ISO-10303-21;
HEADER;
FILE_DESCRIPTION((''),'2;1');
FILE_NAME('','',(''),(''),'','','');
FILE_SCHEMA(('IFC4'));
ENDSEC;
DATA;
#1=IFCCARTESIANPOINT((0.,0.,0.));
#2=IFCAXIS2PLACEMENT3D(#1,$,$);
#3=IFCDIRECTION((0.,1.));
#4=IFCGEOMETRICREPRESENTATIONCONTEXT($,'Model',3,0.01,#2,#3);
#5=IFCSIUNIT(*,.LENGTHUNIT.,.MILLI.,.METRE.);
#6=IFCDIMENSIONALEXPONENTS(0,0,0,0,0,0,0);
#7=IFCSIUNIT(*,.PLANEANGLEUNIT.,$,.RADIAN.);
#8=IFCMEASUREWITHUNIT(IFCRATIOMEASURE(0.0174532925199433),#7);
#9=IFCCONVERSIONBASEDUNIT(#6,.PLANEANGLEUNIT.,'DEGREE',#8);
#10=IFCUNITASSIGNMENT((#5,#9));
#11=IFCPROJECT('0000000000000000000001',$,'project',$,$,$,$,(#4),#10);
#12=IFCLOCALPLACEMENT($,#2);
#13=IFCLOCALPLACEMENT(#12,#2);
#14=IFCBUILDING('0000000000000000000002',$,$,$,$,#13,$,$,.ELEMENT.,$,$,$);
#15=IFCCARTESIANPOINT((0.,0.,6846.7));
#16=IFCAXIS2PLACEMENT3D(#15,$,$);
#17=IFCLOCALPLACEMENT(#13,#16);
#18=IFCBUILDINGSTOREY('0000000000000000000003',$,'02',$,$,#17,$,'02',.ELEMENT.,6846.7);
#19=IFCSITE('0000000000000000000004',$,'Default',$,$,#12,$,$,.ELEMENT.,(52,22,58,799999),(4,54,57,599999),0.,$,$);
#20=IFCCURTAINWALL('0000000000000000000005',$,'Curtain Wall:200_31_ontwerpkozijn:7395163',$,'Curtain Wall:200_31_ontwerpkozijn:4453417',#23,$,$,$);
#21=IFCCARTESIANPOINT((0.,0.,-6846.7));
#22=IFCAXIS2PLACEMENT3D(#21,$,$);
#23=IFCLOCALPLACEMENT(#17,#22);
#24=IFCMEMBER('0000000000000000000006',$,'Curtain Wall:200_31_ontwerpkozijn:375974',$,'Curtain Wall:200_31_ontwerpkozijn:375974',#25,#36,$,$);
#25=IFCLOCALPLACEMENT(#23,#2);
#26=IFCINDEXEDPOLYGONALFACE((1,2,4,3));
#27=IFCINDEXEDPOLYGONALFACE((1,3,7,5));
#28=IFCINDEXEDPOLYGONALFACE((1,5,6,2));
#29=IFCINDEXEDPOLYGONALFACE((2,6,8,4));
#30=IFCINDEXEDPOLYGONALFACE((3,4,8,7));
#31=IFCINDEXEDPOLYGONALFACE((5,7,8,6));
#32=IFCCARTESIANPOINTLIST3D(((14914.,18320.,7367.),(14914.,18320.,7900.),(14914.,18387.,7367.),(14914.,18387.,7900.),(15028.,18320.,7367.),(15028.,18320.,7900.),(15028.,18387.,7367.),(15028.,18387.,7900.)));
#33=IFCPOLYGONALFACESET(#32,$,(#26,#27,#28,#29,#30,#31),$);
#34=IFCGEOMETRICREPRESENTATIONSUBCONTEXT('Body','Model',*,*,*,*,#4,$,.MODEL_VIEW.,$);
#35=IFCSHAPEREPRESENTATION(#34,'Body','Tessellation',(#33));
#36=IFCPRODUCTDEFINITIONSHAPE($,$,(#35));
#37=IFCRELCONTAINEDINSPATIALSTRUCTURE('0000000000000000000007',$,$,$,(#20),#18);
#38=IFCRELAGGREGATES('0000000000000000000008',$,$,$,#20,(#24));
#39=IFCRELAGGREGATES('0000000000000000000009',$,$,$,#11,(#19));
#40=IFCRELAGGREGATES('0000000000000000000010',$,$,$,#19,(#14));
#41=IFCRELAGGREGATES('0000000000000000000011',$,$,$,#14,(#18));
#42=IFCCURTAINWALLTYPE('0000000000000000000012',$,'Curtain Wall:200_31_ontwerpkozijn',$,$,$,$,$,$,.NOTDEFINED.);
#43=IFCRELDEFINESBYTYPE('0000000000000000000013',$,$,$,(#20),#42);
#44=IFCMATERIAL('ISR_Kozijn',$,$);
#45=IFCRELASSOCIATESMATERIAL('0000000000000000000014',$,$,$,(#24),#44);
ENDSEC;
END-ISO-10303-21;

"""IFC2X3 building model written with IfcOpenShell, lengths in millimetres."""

from ifc_helpers import new_model, entity, si_unit, converted_unit, direction, frame, frame_2d, origin, place, context, subcontext, project, spatial, rectangle, extrude, material, type_object, element, aggregate, save


model = new_model("IFC2X3")

# Units and contexts
model_context = context("Model", 3, precision=0.01, world=origin(), true_north=direction((0.0, 1.0)))
body_context = subcontext(model_context, "Body", "Model", "MODEL_VIEW")
ifc_project = project(units=[si_unit("LENGTHUNIT", "METRE", prefix="MILLI"), converted_unit("PLANEANGLEUNIT", "DEGREE", entity("IfcRatioMeasure", 0.0174532925199433), si_unit("PLANEANGLEUNIT", "RADIAN"), dimensions=[0, 0, 0, 0, 0, 0, 0])], contexts=[model_context])

# Site, building, storey
site_placement = place(None, origin())
site = spatial("IfcSite", under=ifc_project, at=site_placement, Name="Default", CompositionType="ELEMENT", RefLatitude=(52, 22, 58, 799999), RefLongitude=(4, 54, 57, 599999), RefElevation=0.0)
building_placement = place(site_placement, origin())
building = spatial("IfcBuilding", under=site, at=building_placement, CompositionType="ELEMENT")
storey_placement = place(building_placement, frame((0.0, 0.0, 6846.7)))
storey = spatial("IfcBuildingStorey", under=building, at=storey_placement, Name="02", LongName="02", CompositionType="ELEMENT", Elevation=6846.7)

# Shared definitions
curtain_wall_type = type_object("IfcCurtainWallType", Name="Curtain Wall:200_31_ontwerpkozijn", PredefinedType="NOTDEFINED")
ifc_material = material(Name="ISR_Kozijn")

# Curtain wall, member
curtain_wall_1_placement = place(storey_placement, frame((0.0, 0.0, -6846.7)))
curtain_wall_1 = element("IfcCurtainWall", 1, at=curtain_wall_1_placement, inside=storey, type_object=curtain_wall_type, Name="Curtain Wall:200_31_ontwerpkozijn:7395163", ObjectType="Curtain Wall:200_31_ontwerpkozijn:4453417")
member_1_placement = place(curtain_wall_1_placement, origin())
member_1 = element("IfcMember", 2, at=member_1_placement, material=ifc_material, Name="Curtain Wall:200_31_ontwerpkozijn:375974", ObjectType="Curtain Wall:200_31_ontwerpkozijn:375974", context=body_context, shape_type="SweptSolid", body=[
    extrude(rectangle(XDim=114.0, YDim=67.0, at=frame_2d((0.0, 0.0), x_axis=(1.0, 0.0))), frame((14971.0, 18353.5, 7367.0), z_axis=(0.0, 0.0, 1.0), x_axis=(-1.0, 0.0, 0.0)), (0.0, 0.0, 1.0), 533.0),
])
aggregate(curtain_wall_1, [member_1])

save(model, "model.ifc")
